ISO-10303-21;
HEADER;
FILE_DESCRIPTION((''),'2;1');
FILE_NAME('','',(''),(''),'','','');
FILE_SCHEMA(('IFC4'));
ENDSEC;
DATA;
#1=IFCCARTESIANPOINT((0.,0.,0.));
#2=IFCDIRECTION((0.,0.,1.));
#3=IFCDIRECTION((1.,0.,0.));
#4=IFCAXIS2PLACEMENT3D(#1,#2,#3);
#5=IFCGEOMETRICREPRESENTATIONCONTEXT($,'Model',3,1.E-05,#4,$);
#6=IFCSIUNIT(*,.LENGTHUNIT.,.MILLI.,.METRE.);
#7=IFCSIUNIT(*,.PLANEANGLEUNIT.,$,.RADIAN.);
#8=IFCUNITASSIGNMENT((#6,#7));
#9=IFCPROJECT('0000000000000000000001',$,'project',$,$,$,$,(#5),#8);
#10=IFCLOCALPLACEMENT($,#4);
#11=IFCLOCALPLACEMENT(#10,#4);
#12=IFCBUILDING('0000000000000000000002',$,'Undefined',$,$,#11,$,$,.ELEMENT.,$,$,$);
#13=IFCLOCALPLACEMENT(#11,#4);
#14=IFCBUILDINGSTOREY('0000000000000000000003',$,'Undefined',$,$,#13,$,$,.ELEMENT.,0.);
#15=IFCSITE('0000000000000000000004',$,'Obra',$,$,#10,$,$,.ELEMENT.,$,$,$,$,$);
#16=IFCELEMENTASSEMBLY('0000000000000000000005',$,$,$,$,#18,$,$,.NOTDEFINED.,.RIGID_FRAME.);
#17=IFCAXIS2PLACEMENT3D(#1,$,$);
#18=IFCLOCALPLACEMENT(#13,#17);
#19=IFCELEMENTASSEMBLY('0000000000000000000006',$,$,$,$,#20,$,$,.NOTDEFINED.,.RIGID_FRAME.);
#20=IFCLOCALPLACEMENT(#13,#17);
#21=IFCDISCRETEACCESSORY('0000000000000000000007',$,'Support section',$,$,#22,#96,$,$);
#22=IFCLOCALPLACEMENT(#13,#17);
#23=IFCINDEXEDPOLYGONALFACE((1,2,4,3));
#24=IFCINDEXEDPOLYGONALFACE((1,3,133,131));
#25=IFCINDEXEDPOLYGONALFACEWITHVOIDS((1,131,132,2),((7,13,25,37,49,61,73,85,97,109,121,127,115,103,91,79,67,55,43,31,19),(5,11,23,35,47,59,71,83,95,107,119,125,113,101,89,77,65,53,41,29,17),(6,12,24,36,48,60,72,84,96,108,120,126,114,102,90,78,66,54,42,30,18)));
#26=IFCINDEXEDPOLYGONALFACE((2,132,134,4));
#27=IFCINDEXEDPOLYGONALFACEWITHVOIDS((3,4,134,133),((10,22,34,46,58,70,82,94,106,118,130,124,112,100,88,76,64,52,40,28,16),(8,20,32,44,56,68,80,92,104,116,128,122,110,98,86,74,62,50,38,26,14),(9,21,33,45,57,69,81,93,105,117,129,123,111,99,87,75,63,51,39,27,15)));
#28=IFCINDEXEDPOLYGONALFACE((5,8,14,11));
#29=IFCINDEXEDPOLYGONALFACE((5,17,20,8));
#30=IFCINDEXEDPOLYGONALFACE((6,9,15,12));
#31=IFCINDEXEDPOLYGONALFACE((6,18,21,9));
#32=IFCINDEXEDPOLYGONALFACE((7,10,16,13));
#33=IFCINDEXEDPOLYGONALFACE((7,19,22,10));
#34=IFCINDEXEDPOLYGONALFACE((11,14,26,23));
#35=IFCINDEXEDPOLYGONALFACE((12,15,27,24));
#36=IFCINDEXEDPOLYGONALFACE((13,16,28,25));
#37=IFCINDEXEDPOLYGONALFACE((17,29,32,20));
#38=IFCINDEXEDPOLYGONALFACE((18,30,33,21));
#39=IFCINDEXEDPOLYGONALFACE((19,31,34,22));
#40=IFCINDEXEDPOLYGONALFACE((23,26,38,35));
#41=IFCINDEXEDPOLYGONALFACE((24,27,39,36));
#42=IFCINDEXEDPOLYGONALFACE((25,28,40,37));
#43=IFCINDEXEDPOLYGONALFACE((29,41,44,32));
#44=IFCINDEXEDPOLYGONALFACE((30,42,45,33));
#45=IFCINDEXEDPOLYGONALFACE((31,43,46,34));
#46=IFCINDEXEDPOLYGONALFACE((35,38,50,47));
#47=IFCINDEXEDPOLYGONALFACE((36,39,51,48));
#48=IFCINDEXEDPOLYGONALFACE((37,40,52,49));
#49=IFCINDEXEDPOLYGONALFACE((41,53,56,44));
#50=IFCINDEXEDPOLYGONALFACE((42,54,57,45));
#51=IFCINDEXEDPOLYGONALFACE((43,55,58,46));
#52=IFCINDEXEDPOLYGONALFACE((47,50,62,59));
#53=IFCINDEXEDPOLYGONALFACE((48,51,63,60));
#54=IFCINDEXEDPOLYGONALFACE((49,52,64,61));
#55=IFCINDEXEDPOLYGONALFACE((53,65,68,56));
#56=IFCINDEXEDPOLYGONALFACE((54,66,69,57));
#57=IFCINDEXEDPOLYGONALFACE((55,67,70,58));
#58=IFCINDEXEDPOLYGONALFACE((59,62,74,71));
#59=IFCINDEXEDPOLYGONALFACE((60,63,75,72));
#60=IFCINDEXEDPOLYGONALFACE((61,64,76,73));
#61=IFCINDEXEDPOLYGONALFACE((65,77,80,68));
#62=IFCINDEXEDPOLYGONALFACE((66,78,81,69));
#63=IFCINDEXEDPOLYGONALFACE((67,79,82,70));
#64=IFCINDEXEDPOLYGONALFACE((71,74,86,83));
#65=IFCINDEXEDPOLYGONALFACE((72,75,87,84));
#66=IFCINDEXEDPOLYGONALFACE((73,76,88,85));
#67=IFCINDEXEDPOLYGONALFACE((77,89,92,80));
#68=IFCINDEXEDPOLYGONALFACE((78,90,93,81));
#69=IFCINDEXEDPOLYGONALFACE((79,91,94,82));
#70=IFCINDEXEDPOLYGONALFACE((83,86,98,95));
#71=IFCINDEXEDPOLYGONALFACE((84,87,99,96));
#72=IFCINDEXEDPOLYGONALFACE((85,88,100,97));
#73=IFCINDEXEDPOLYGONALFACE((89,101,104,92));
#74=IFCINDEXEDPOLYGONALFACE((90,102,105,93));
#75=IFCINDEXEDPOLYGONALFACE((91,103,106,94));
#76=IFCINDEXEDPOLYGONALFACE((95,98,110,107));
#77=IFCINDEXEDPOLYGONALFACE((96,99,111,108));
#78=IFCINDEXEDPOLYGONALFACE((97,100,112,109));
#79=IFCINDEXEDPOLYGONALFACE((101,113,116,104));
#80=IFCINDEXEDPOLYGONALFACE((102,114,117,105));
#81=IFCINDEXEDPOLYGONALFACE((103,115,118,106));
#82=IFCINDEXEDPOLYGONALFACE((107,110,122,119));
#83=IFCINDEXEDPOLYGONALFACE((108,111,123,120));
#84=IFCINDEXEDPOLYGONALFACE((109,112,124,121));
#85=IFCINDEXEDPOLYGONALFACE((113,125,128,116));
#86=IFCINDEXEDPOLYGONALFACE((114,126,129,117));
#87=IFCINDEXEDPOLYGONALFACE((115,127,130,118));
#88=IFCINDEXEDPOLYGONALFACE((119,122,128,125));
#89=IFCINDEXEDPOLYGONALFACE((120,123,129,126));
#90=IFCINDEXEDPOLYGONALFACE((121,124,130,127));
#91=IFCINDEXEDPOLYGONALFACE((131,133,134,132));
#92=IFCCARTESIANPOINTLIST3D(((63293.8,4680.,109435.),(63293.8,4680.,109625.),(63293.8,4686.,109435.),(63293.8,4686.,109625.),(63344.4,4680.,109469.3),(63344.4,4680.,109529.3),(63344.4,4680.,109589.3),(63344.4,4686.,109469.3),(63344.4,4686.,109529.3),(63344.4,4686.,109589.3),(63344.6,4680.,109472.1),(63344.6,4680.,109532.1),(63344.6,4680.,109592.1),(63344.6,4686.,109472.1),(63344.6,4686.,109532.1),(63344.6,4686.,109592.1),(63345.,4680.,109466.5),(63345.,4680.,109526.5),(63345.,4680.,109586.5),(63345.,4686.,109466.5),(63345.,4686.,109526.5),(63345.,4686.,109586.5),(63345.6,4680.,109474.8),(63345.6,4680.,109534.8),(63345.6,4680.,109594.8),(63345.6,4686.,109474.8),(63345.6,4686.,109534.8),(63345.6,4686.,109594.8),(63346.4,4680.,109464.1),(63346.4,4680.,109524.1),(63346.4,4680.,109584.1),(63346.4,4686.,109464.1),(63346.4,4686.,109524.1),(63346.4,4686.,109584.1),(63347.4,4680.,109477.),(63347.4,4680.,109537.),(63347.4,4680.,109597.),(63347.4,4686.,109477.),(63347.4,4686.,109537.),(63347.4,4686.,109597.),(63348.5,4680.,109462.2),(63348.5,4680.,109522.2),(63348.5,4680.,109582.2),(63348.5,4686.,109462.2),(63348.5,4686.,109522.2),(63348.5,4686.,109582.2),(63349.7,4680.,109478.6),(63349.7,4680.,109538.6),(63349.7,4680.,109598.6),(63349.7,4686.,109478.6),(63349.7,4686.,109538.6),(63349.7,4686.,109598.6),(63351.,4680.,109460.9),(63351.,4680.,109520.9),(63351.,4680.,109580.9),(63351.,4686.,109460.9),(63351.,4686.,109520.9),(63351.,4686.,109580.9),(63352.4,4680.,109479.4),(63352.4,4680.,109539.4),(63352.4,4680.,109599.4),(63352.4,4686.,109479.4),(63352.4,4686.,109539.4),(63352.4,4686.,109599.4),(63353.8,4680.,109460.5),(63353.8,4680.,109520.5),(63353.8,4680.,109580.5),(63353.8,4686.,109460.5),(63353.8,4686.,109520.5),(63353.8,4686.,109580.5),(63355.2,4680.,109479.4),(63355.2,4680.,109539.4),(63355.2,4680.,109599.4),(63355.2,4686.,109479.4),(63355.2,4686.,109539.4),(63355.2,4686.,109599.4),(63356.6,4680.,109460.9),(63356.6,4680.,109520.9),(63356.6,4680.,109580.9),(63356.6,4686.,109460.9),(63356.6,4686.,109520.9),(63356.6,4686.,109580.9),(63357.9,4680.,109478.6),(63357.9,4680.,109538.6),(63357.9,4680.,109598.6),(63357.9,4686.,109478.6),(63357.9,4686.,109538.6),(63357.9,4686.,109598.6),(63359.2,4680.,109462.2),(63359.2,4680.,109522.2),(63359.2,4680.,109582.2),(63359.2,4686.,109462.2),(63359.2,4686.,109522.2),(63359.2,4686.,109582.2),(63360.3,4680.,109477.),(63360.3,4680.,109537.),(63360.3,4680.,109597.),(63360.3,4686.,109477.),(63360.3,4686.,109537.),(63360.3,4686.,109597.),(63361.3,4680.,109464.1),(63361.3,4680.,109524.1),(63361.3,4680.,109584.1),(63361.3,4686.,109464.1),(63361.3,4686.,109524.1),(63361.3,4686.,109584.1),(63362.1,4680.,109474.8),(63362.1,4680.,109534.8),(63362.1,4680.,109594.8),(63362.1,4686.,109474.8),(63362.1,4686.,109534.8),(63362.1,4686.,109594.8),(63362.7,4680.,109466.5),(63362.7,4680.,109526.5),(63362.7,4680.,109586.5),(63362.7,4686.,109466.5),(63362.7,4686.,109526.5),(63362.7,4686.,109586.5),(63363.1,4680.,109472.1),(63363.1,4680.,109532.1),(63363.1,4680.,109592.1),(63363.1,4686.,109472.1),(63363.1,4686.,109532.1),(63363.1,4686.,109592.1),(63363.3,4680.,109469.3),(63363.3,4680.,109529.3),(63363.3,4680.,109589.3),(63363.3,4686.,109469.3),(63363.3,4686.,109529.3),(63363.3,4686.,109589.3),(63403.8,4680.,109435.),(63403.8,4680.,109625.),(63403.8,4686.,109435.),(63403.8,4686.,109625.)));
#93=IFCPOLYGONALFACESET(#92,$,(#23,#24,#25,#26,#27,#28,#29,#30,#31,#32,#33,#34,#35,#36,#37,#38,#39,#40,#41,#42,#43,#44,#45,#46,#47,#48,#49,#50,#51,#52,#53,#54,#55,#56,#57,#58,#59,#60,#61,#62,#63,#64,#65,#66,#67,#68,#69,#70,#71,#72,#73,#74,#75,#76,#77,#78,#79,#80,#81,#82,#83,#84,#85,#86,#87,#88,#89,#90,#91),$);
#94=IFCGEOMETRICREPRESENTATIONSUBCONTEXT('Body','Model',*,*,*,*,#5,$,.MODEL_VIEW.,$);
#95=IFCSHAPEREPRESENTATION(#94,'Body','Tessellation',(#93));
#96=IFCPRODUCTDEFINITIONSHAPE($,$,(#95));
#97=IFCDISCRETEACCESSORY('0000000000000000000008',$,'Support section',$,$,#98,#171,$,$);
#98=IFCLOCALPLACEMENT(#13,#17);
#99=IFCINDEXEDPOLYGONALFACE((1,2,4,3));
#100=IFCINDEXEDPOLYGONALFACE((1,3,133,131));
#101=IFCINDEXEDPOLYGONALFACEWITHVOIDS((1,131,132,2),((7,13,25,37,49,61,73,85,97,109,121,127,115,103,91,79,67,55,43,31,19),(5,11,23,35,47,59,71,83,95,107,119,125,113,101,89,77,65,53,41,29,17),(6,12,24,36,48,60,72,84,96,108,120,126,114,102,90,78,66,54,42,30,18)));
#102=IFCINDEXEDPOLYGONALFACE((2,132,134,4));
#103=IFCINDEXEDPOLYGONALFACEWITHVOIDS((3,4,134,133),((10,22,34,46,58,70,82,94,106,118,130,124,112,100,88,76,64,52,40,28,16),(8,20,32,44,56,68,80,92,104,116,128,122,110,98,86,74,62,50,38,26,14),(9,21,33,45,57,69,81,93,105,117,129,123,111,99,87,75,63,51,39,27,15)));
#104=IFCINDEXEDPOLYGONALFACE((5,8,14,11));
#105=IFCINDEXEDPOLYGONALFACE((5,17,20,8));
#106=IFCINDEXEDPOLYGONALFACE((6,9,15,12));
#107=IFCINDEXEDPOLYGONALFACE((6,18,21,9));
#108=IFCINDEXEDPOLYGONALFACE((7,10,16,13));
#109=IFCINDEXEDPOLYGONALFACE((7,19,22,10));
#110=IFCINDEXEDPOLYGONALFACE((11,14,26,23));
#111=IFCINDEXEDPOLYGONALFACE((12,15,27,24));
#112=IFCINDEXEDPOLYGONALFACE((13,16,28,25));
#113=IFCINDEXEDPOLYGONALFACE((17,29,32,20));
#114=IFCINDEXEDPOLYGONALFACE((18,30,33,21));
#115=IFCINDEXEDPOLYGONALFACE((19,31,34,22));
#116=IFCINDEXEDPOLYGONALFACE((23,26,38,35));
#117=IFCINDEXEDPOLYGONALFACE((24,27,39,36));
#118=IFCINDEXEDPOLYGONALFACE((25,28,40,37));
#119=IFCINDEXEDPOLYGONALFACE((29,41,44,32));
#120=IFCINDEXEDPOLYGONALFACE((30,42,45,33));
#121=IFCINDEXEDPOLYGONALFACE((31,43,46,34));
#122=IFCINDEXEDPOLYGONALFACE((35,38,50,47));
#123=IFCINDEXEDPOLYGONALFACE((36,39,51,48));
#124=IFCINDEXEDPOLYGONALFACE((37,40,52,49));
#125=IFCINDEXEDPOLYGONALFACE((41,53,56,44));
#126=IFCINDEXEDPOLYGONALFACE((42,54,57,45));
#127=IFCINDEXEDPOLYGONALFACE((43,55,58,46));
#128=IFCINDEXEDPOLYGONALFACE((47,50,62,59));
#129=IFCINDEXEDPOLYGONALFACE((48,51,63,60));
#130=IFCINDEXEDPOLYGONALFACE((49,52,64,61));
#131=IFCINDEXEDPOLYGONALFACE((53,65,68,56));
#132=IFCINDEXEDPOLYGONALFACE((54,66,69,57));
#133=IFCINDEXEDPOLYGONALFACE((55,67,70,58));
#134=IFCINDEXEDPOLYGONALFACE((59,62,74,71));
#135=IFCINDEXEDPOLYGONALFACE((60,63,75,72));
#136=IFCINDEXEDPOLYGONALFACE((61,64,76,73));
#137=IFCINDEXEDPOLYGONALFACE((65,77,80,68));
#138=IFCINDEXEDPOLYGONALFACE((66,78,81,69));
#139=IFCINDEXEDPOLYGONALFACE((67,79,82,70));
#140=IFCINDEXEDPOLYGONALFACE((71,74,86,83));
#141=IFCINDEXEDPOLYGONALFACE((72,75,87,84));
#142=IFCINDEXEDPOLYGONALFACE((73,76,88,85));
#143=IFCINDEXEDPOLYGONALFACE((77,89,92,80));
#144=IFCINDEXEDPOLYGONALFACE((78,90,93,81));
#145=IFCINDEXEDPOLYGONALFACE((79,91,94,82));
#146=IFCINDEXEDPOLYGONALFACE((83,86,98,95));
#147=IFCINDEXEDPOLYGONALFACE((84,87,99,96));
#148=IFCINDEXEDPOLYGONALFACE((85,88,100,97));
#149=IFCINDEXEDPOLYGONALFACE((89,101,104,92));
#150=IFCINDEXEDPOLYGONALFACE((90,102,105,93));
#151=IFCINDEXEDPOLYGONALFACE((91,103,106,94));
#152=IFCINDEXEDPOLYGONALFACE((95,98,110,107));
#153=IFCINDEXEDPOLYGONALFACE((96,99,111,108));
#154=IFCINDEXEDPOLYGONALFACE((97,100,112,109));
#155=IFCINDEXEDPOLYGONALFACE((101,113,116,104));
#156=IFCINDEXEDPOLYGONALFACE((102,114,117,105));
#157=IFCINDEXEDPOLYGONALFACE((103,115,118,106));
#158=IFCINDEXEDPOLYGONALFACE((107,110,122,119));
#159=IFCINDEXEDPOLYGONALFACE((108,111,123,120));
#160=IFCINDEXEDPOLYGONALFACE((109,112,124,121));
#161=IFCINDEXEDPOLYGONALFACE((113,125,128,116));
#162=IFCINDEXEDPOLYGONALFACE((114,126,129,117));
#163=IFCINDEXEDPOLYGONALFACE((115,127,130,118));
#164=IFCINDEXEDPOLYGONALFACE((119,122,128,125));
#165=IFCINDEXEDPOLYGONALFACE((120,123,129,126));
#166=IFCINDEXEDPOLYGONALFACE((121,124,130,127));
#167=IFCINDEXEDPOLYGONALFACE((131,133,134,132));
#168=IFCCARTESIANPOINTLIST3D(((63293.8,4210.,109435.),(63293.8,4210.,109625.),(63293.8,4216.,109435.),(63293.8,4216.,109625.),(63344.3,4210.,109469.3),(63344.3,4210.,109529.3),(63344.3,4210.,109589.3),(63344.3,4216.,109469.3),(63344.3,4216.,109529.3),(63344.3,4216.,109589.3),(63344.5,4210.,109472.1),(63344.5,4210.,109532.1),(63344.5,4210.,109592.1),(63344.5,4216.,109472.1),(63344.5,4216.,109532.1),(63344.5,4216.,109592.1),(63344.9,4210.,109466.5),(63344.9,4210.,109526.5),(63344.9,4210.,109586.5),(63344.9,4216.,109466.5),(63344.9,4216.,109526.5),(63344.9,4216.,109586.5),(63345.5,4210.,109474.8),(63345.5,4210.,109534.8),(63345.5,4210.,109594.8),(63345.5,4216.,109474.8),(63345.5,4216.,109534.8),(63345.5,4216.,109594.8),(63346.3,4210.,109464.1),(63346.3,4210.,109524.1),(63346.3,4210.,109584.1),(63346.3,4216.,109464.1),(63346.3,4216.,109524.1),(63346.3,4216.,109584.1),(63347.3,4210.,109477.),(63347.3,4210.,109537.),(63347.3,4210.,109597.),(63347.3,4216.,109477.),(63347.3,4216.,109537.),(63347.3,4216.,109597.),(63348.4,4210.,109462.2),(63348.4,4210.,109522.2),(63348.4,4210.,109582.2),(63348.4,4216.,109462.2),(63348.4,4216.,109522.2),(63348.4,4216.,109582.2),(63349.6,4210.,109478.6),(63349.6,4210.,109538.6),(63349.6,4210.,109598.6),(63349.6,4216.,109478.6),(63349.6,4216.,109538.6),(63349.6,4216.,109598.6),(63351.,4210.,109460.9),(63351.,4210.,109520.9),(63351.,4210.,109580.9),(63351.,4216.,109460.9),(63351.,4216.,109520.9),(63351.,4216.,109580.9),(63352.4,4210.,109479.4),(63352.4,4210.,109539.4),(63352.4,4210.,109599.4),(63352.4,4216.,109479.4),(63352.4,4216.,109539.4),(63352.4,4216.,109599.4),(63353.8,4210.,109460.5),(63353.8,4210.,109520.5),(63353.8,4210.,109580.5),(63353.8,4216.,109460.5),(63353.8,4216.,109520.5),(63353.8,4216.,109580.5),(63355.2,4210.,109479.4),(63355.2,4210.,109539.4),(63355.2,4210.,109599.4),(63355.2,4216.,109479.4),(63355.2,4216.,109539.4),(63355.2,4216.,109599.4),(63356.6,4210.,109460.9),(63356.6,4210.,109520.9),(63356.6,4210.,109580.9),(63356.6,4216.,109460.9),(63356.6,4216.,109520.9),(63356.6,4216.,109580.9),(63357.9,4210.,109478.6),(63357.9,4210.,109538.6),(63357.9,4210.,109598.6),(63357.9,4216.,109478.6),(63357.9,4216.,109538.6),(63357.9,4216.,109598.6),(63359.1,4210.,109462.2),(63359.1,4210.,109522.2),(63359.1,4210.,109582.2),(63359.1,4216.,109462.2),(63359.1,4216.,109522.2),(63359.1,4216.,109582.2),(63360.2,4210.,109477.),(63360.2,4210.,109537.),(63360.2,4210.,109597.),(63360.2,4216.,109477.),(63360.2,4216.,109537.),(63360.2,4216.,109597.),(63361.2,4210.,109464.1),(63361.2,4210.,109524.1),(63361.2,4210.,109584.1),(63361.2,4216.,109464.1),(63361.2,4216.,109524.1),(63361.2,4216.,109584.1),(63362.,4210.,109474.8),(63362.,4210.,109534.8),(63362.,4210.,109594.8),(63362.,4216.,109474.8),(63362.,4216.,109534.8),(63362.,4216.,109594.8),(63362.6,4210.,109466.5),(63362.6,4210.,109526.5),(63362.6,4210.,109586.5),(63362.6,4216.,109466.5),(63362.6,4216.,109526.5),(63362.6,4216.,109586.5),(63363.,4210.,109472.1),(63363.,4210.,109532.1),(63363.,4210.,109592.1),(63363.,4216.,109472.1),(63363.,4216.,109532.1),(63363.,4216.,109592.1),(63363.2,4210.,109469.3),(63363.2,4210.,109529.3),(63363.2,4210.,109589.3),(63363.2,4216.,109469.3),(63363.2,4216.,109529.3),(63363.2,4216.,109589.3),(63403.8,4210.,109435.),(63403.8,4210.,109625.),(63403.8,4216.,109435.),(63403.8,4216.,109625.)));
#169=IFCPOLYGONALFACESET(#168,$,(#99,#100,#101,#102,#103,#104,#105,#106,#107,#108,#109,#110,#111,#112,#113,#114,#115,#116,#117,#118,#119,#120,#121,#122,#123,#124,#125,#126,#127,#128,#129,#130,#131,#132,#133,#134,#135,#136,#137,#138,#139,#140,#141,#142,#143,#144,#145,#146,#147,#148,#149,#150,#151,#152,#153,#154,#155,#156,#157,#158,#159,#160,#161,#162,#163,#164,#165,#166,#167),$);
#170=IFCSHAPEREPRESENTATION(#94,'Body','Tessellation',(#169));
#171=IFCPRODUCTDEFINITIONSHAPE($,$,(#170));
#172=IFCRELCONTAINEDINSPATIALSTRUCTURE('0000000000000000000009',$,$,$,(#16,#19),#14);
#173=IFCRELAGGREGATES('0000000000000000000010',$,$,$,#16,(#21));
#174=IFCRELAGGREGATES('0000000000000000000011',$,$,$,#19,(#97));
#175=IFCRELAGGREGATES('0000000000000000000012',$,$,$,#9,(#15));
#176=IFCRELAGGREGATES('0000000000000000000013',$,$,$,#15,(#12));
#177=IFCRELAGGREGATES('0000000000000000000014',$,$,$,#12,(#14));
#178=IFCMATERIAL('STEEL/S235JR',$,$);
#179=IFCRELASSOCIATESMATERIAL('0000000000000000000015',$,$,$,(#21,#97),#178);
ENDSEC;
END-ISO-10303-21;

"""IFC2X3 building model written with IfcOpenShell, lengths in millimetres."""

from ifc_helpers import new_model, si_unit, frame, origin_with_axes, origin_2d_with_axis, place, context, subcontext, project, spatial, rectangle, circle, extrude, source, transform, mapped, material, element, aggregate, save


model = new_model("IFC2X3")

# Units and contexts
model_context = context("Model", 3, precision=1e-05, world=origin_with_axes())
body_context = subcontext(model_context, "Body", "Model", "MODEL_VIEW")
ifc_project = project(units=[si_unit("LENGTHUNIT", "METRE", prefix="MILLI"), si_unit("PLANEANGLEUNIT", "RADIAN")], contexts=[model_context])

# Site, building, storey
site_placement = place(None, origin_with_axes())
site = spatial("IfcSite", under=ifc_project, at=site_placement, Name="Obra", CompositionType="ELEMENT")
building_placement = place(site_placement, origin_with_axes())
building = spatial("IfcBuilding", under=site, at=building_placement, Name="Undefined", CompositionType="ELEMENT")
storey_placement = place(building_placement, origin_with_axes())
storey = spatial("IfcBuildingStorey", under=building, at=storey_placement, Name="Undefined", CompositionType="ELEMENT", Elevation=0.0)

# Element assemblies
ifc_material_1 = material(Name="STEEL/S235JR")
assembly_1_placement = place(storey_placement, origin_with_axes())
assembly_1 = element("IfcElementAssembly", 1, at=assembly_1_placement, inside=storey, AssemblyPlace="NOTDEFINED", PredefinedType="RIGID_FRAME")
assembly_2_placement = place(storey_placement, origin_with_axes())
assembly_2 = element("IfcElementAssembly", 2, at=assembly_2_placement, inside=storey, AssemblyPlace="NOTDEFINED", PredefinedType="RIGID_FRAME")

# Shared definitions
shared_shape_1 = source(origin_with_axes(), body_context, "Body", "SweptSolid", [
    extrude(circle(Radius=9.5, at=origin_2d_with_axis()), frame((0.0, -9.2, 0.0), z_axis=(0.0, 1.0, 0.0), x_axis=(1.0, 0.0, 0.0)), (0.0, 0.0, 1.0), 6.2),
])

# Discrete accessories, openings
discrete_accessory_1_placement = place(assembly_1_placement, frame((63348.8, 4683.0, 109435.0), z_axis=(0.0, 0.0, 1.0), x_axis=(-1.0, 0.000126, 0.0)))
discrete_accessory_1 = element("IfcDiscreteAccessory", 3, at=discrete_accessory_1_placement, material=ifc_material_1, Name="Support section", context=body_context, shape_type="SweptSolid", body=[
    extrude(rectangle(XDim=6.0, YDim=110.0, at=origin_2d_with_axis()), frame((0.0, 0.0, 190.0), z_axis=(0.0, 0.0, -1.0), x_axis=(0.0, 1.0, 0.0)), (0.0, 0.0, 1.0), 190.0),
])
opening_1_placement = place(assembly_1_placement, frame((63303.8, 4689.1, 109650.0), z_axis=(1.0, -0.000126, 0.0), x_axis=(0.0, 0.0, -1.0)))
element("IfcOpeningElement", 4, at=opening_1_placement, cuts=discrete_accessory_1, ObjectType="Opening", context=body_context, shape_type="MappedRepresentation", body=[
    mapped(shared_shape_1, transform((60.0, 0.0, 50.0))),
    mapped(shared_shape_1, transform((120.0, 0.0, 50.0))),
    mapped(shared_shape_1, transform((180.0, 0.0, 50.0))),
])
aggregate(assembly_1, [discrete_accessory_1])
discrete_accessory_2_placement = place(assembly_2_placement, frame((63348.8, 4213.0, 109435.0), z_axis=(0.0, 0.0, 1.0), x_axis=(-1.0, 0.000126, 0.0)))
discrete_accessory_2 = element("IfcDiscreteAccessory", 5, at=discrete_accessory_2_placement, material=ifc_material_1, Name="Support section", context=body_context, shape_type="SweptSolid", body=[
    extrude(rectangle(XDim=6.0, YDim=110.0, at=origin_2d_with_axis()), frame((0.0, 0.0, 190.0), z_axis=(0.0, 0.0, -1.0), x_axis=(0.0, 1.0, 0.0)), (0.0, 0.0, 1.0), 190.0),
])
opening_2_placement = place(assembly_2_placement, frame((63303.8, 4219.1, 109650.0), z_axis=(1.0, -0.000126, 0.0), x_axis=(0.0, 0.0, -1.0)))
element("IfcOpeningElement", 6, at=opening_2_placement, cuts=discrete_accessory_2, ObjectType="Opening", context=body_context, shape_type="MappedRepresentation", body=[
    mapped(shared_shape_1, transform((60.0, 0.0, 50.0))),
    mapped(shared_shape_1, transform((120.0, 0.0, 50.0))),
    mapped(shared_shape_1, transform((180.0, 0.0, 50.0))),
])
aggregate(assembly_2, [discrete_accessory_2])

save(model, "model.ifc")
